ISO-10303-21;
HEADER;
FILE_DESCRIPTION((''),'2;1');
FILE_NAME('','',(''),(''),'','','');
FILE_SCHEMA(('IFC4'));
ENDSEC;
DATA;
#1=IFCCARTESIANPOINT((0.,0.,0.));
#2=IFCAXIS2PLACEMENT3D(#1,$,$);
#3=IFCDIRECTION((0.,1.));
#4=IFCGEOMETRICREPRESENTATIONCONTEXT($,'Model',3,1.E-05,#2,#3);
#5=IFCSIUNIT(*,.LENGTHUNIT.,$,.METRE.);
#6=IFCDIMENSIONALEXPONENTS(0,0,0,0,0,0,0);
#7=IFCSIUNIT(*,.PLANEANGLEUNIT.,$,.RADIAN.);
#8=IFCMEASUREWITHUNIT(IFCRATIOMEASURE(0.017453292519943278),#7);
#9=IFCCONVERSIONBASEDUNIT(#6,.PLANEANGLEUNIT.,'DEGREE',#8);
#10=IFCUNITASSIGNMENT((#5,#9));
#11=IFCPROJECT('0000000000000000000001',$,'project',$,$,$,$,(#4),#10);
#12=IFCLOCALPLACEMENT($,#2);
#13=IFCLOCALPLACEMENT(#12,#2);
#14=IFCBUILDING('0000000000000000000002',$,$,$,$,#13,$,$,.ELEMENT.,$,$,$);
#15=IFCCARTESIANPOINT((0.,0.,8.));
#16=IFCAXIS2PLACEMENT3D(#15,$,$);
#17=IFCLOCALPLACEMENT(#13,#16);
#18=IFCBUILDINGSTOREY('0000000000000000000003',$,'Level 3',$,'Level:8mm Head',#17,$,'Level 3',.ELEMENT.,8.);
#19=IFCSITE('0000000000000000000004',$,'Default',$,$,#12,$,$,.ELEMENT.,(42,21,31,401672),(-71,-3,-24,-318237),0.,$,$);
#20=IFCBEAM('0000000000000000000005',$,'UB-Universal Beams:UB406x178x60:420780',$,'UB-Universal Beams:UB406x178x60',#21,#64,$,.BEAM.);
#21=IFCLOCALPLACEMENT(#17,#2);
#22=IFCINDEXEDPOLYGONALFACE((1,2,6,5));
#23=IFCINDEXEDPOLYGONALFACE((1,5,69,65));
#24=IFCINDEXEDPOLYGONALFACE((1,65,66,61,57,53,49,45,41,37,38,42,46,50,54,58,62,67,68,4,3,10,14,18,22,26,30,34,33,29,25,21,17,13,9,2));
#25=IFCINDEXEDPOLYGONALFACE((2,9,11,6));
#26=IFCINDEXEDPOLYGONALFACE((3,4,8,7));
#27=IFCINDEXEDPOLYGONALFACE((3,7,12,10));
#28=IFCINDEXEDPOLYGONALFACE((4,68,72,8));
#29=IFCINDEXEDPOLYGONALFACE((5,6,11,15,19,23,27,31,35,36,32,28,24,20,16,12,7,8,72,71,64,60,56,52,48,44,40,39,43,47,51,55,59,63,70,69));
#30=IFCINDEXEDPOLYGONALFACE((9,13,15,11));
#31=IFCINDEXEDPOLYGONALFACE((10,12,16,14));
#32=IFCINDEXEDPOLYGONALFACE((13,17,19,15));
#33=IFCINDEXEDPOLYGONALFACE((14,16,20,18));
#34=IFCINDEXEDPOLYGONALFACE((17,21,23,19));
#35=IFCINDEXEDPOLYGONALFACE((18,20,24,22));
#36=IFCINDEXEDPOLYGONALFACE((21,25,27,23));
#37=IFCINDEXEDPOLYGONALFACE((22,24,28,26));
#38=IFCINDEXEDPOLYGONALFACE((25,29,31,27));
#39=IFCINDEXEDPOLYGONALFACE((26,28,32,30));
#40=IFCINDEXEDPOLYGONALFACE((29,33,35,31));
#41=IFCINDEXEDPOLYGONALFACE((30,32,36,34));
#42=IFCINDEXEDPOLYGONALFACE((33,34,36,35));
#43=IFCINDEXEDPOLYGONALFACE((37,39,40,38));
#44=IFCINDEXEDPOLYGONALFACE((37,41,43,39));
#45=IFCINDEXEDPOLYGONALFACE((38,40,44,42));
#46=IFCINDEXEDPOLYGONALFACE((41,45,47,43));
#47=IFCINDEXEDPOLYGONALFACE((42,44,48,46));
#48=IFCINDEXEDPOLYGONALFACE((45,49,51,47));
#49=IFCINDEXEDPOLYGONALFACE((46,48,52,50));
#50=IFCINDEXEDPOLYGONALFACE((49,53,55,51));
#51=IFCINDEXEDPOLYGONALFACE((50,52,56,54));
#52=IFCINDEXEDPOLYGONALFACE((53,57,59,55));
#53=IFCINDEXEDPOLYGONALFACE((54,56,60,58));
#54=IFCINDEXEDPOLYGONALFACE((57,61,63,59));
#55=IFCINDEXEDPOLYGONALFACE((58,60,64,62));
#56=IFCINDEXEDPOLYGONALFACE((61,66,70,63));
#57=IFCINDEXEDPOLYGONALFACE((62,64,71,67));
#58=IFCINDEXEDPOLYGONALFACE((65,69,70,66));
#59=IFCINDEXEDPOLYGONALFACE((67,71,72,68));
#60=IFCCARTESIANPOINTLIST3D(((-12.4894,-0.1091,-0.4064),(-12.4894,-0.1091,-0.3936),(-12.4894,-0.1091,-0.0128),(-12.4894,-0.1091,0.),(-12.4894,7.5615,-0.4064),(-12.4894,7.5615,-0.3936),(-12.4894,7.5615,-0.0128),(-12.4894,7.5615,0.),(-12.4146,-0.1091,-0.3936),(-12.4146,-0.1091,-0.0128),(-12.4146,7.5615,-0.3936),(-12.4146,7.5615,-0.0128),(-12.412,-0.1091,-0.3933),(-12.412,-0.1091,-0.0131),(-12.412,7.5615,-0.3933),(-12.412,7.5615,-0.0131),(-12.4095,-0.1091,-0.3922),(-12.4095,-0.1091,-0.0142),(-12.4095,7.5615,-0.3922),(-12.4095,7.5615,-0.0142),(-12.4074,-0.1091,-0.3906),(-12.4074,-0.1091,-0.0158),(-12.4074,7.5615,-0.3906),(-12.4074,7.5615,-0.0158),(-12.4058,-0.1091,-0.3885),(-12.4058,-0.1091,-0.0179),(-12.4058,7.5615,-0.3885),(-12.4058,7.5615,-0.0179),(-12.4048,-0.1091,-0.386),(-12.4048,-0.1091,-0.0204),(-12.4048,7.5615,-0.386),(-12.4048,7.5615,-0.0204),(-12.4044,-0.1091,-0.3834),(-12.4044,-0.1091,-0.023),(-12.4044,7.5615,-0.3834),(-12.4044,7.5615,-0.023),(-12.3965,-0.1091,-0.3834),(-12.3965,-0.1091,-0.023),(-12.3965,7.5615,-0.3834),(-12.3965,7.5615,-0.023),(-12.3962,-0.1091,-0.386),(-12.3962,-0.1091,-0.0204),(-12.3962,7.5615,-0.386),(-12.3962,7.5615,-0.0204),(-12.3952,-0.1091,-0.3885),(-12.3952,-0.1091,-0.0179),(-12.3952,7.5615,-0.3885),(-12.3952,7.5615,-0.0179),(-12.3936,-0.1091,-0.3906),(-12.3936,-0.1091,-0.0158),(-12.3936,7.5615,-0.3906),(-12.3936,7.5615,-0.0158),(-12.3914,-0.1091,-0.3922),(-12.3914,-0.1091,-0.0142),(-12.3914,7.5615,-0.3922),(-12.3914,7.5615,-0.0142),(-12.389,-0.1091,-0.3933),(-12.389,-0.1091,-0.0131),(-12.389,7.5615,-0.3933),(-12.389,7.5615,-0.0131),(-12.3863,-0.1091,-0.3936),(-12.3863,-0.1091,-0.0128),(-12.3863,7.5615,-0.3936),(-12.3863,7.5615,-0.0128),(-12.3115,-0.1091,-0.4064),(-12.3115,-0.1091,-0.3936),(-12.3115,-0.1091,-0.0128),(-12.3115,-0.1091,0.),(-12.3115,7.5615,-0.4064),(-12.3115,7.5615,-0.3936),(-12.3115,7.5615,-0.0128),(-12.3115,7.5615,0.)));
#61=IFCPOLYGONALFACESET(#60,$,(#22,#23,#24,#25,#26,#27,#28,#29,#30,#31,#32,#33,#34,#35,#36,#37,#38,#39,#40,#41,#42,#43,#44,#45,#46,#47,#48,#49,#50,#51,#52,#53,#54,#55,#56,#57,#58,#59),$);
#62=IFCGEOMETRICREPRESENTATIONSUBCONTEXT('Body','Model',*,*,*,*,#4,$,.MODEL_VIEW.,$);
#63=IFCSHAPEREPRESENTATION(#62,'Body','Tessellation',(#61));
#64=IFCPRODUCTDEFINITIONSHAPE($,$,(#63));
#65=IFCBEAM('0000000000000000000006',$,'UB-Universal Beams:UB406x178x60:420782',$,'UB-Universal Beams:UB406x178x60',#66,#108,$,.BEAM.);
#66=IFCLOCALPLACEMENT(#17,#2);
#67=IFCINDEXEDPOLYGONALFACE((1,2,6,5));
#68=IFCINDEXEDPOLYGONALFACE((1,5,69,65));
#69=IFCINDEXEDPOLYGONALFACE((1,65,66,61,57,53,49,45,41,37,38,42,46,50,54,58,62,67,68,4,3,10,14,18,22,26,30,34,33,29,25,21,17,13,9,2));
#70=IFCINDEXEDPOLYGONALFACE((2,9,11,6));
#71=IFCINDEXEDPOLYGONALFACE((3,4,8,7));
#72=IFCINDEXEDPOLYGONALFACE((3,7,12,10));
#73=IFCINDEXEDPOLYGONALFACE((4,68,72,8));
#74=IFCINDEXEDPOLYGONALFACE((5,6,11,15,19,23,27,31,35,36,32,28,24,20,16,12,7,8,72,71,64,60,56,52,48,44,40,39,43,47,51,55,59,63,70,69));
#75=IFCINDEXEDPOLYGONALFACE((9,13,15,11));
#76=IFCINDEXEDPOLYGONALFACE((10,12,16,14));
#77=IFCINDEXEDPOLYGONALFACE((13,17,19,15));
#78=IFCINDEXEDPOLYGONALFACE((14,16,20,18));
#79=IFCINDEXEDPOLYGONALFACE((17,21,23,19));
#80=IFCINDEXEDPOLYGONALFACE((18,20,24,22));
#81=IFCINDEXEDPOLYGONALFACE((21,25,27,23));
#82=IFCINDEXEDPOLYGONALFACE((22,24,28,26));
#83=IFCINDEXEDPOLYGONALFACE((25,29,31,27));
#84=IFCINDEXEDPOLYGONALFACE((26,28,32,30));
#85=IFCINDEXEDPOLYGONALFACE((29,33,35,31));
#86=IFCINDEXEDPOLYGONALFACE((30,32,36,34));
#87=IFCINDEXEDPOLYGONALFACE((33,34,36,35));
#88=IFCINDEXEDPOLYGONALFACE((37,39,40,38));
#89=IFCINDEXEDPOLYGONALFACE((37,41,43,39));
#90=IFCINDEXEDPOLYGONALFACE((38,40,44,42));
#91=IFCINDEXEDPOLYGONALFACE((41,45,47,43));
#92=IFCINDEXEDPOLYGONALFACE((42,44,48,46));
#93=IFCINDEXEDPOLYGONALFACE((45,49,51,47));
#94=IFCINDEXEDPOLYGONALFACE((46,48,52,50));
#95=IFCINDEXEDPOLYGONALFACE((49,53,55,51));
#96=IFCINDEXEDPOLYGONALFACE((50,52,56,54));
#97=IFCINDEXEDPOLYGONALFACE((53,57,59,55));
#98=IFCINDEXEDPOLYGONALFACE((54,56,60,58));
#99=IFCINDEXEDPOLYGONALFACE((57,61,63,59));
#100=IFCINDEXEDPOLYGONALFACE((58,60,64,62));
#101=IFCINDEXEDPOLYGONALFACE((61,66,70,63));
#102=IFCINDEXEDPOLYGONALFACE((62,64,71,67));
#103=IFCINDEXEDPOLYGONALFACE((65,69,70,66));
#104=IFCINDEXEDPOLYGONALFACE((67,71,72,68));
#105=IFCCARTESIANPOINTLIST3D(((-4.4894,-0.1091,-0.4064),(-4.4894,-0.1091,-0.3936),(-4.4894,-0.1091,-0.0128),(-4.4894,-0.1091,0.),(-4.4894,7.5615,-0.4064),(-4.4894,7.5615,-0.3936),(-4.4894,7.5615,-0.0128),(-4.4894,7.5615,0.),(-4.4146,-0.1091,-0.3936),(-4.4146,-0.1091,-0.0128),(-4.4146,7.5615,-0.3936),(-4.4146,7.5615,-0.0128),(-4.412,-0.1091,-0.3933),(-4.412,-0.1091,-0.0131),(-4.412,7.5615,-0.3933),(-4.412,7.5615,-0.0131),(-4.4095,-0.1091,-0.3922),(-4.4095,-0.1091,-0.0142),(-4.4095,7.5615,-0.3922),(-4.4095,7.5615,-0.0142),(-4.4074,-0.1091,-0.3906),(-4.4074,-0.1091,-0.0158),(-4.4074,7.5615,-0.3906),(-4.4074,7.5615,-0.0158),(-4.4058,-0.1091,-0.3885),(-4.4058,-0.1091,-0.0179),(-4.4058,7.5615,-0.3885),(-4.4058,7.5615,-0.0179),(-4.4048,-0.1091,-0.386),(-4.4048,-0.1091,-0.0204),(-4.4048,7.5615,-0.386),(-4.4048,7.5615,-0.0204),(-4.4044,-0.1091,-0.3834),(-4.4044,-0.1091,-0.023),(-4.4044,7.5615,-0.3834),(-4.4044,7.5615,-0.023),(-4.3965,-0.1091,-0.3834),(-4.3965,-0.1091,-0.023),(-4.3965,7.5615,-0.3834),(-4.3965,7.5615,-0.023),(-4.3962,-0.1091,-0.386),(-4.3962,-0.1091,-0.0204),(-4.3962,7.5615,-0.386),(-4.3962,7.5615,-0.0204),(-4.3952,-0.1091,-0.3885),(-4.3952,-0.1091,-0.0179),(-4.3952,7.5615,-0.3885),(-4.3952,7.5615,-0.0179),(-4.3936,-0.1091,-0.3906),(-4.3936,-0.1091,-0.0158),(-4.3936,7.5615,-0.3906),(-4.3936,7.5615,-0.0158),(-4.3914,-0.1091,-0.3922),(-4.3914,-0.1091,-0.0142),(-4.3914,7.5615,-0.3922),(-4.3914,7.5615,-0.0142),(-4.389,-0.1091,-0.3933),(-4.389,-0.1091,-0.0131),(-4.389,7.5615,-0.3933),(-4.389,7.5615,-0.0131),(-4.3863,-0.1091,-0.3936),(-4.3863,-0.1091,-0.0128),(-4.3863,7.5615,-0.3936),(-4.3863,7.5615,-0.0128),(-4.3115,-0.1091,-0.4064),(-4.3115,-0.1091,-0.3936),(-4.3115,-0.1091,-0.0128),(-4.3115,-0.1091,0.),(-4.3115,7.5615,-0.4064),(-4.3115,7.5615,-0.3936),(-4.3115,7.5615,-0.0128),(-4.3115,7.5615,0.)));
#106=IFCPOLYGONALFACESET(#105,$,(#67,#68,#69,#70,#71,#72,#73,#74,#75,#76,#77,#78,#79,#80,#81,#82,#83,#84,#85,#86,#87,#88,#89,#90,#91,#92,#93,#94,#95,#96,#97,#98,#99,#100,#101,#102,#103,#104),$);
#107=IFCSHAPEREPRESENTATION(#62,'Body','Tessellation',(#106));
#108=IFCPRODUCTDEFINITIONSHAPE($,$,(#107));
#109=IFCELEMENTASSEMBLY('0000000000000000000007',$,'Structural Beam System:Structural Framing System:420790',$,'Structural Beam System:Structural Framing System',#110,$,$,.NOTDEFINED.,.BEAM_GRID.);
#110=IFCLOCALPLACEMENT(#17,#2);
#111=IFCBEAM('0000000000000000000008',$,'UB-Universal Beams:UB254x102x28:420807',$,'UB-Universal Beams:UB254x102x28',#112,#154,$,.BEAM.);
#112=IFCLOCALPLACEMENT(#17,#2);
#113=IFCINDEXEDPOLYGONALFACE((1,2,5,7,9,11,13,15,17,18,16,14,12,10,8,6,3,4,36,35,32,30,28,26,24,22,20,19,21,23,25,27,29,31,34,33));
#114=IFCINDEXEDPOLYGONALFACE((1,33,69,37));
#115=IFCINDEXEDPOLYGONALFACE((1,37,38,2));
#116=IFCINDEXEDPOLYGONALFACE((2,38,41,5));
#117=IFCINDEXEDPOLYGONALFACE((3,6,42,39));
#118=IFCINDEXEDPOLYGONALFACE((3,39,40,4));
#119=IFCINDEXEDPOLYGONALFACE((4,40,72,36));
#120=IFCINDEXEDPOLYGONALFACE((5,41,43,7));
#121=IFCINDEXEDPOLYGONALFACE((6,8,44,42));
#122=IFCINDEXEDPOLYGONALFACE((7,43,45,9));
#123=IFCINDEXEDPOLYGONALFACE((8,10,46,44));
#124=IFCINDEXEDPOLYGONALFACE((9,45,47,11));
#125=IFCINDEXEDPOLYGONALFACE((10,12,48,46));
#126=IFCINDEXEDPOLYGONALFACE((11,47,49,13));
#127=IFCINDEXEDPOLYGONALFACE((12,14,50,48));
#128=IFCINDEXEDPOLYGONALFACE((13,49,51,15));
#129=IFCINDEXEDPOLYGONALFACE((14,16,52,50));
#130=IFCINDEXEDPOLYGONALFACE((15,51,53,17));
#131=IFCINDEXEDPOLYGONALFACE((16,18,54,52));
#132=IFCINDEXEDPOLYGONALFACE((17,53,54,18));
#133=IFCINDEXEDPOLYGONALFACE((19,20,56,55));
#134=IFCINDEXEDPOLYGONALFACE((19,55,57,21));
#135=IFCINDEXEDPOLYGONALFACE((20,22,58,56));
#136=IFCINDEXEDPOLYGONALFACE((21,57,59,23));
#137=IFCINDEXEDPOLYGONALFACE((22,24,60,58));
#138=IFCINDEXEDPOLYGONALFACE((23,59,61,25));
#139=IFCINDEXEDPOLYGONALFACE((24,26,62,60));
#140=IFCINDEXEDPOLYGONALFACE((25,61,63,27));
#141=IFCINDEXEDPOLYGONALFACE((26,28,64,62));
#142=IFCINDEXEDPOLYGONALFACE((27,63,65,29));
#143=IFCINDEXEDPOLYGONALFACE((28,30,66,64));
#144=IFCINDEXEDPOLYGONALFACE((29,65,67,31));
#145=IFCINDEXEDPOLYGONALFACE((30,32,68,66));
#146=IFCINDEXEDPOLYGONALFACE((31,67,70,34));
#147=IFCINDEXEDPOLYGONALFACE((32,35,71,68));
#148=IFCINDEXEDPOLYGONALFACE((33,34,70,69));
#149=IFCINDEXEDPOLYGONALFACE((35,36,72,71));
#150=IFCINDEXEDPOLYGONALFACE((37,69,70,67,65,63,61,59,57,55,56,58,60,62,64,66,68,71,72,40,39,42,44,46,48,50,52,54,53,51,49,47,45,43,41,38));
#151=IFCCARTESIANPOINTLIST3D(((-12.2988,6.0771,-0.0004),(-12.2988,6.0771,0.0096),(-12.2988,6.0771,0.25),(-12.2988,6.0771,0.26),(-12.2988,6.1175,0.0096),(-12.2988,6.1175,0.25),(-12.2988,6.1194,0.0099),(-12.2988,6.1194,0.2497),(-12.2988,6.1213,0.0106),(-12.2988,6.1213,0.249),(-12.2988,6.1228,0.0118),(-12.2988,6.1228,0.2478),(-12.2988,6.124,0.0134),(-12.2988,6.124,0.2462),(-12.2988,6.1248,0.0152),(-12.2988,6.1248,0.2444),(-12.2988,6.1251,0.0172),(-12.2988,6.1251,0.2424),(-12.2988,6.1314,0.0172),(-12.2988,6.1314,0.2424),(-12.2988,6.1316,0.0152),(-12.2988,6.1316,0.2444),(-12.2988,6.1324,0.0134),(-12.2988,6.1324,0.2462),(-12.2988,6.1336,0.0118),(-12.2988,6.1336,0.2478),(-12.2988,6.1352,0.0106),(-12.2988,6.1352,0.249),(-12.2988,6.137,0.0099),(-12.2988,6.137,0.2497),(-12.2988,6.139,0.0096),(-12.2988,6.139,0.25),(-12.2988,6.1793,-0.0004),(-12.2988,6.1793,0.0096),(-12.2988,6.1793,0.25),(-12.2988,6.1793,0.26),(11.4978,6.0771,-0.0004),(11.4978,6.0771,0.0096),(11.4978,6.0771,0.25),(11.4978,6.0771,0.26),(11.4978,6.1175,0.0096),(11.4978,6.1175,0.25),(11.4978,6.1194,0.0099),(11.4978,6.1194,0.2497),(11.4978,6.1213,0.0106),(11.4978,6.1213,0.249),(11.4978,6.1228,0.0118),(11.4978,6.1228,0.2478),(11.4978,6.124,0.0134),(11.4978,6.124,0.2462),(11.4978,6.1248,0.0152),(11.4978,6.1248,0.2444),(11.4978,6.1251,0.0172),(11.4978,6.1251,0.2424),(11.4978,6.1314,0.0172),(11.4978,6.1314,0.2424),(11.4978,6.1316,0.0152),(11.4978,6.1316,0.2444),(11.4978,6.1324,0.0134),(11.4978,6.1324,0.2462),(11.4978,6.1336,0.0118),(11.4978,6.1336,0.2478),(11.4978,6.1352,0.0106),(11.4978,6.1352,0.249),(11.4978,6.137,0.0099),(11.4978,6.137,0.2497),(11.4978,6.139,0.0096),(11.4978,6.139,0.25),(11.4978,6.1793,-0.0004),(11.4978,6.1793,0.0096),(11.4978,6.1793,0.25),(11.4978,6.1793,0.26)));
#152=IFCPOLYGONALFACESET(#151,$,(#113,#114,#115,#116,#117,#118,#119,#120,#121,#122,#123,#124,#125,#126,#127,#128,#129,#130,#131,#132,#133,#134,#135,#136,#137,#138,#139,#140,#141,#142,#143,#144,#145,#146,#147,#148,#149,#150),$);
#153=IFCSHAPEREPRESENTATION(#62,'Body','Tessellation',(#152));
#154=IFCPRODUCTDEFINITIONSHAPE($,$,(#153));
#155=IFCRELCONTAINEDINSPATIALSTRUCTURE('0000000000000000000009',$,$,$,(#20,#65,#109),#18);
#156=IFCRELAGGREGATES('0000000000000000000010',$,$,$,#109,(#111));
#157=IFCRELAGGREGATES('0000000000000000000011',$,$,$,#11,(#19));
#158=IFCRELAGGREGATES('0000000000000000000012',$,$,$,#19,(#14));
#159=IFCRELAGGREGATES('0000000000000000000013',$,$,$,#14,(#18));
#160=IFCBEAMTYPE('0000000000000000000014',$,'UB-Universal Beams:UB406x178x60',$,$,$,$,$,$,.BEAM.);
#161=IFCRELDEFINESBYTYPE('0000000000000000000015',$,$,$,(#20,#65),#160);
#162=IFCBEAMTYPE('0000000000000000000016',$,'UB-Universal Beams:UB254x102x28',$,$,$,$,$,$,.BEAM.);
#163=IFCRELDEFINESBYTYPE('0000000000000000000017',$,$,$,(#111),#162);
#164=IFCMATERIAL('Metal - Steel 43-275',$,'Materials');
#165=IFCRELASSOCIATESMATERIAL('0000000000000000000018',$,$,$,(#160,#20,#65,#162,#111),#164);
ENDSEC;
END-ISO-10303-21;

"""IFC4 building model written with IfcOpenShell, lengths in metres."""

from ifc_helpers import new_model, entity, si_unit, converted_unit, direction, frame, origin, place, context, subcontext, project, spatial, line, arc, indexed_curve, outline, extrude, source, transform, mapped, material, type_object, type_shapes, element, aggregate, save


model = new_model("IFC4")

# Units and contexts
model_context = context("Model", 3, precision=1e-05, world=origin(), true_north=direction((0.0, 1.0)))
body_context = subcontext(model_context, "Body", "Model", "MODEL_VIEW")
ifc_project = project(units=[si_unit("LENGTHUNIT", "METRE"), converted_unit("PLANEANGLEUNIT", "DEGREE", entity("IfcRatioMeasure", 0.017453292519943278), si_unit("PLANEANGLEUNIT", "RADIAN"), dimensions=[0, 0, 0, 0, 0, 0, 0])], contexts=[model_context])

# Site, building, storey
site_placement = place(None, origin())
site = spatial("IfcSite", under=ifc_project, at=site_placement, Name="Default", CompositionType="ELEMENT", RefLatitude=(42, 21, 31, 401672), RefLongitude=(-71, -3, -24, -318237), RefElevation=0.0)
building_placement = place(site_placement, origin())
building = spatial("IfcBuilding", under=site, at=building_placement, CompositionType="ELEMENT")
storey_placement = place(building_placement, frame((0.0, 0.0, 8.0)))
storey = spatial("IfcBuildingStorey", under=building, at=storey_placement, Name="Level 3", ObjectType="Level:8mm Head", LongName="Level 3", CompositionType="ELEMENT", Elevation=8.0)

# Beams
ifc_material_1 = material(Name="Metal - Steel 43-275", Category="Materials")
beam_type_1 = type_object("IfcBeamType", Name="UB-Universal Beams:UB406x178x60", PredefinedType="BEAM", material=ifc_material_1)
shared_shape_1 = source(origin(), body_context, "Body", "SweptSolid", [
    extrude(outline(indexed_curve([(-0.2032, -0.089), (-0.1904, -0.089), (-0.1904, -0.0141), (-0.1874, -0.0069), (-0.1802, -0.0039), (0.1802, -0.0039), (0.1874, -0.0069), (0.1904, -0.0141), (0.1904, -0.089), (0.2032, -0.089), (0.2032, 0.089), (0.1904, 0.089), (0.1904, 0.0142), (0.1874, 0.0069), (0.1802, 0.004), (-0.1802, 0.004), (-0.1874, 0.0069), (-0.1904, 0.0142), (-0.1904, 0.0889), (-0.2032, 0.0889)], segments=[line(1, 2, 3), arc(3, 4, 5), line(5, 6), arc(6, 7, 8), line(8, 9, 10, 11, 12, 13), arc(13, 14, 15), line(15, 16), arc(16, 17, 18), line(18, 19, 20, 1)], self_intersect=False)), frame((-3.8373, 0.0, 0.0), z_axis=(1.0, 0.0, 0.0), x_axis=(0.0, 0.0, -1.0)), (0.0, 0.0, 1.0), 7.6706),
])
type_shapes(beam_type_1, [shared_shape_1])
for number, where, z_axis, x_axis, name in (
    (1, (-12.4005, 3.7282, -0.2032), (0.0, 0.0, 1.0), (0.0, 1.0, 0.0), "UB-Universal Beams:UB406x178x60:420780"),
    (2, (-4.4005, 3.7282, -0.2032), (0.0, 0.0, 1.0), (0.0, 1.0, 0.0), "UB-Universal Beams:UB406x178x60:420782"),
):
    element("IfcBeam", number, at=place(storey_placement, frame(where, z_axis=z_axis, x_axis=x_axis)), inside=storey, type_object=beam_type_1, material=ifc_material_1, Name=name, ObjectType="UB-Universal Beams:UB406x178x60", PredefinedType="BEAM", context=body_context, shape_type="MappedRepresentation", body=[
        mapped(shared_shape_1, transform((0.0, 0.0, 0.0), scale=1.0)),
    ])

# Element assembly, beam
assembly_placement = place(storey_placement, origin())
assembly = element("IfcElementAssembly", 3, at=assembly_placement, inside=storey, Name="Structural Beam System:Structural Framing System:420790", ObjectType="Structural Beam System:Structural Framing System", AssemblyPlace="NOTDEFINED", PredefinedType="BEAM_GRID")
beam_type_2 = type_object("IfcBeamType", Name="UB-Universal Beams:UB254x102x28", PredefinedType="BEAM", material=ifc_material_1)
shared_shape_2 = source(origin(), body_context, "Body", "SweptSolid", [
    extrude(outline(indexed_curve([(-0.1302, -0.0511), (-0.1202, -0.0511), (-0.1202, -0.0107), (-0.118, -0.0054), (-0.1126, -0.0031), (0.1126, -0.0031), (0.118, -0.0054), (0.1202, -0.0107), (0.1202, -0.0511), (0.1302, -0.0511), (0.1302, 0.0511), (0.1202, 0.0511), (0.1202, 0.0108), (0.118, 0.0054), (0.1126, 0.0032), (-0.1126, 0.0032), (-0.118, 0.0054), (-0.1202, 0.0108), (-0.1202, 0.0511), (-0.1302, 0.0511)], segments=[line(1, 2, 3), arc(3, 4, 5), line(5, 6), arc(6, 7, 8), line(8, 9, 10, 11, 12, 13), arc(13, 14, 15), line(15, 16), arc(16, 17, 18), line(18, 19, 20, 1)], self_intersect=False)), frame((-11.8983, 0.0, 0.0), z_axis=(1.0, 0.0, 0.0), x_axis=(0.0, 0.0, -1.0)), (0.0, 0.0, 1.0), 23.7966),
])
type_shapes(beam_type_2, [shared_shape_2])
beam_1_placement = place(assembly_placement, frame((-0.4005, 6.1282, 0.1298)))
beam_1 = element("IfcBeam", 4, at=beam_1_placement, type_object=beam_type_2, material=ifc_material_1, Name="UB-Universal Beams:UB254x102x28:420807", ObjectType="UB-Universal Beams:UB254x102x28", PredefinedType="BEAM", context=body_context, shape_type="MappedRepresentation", body=[
    mapped(shared_shape_2, transform((0.0, 0.0, 0.0), scale=1.0)),
])
aggregate(assembly, [beam_1])

save(model, "model.ifc")
